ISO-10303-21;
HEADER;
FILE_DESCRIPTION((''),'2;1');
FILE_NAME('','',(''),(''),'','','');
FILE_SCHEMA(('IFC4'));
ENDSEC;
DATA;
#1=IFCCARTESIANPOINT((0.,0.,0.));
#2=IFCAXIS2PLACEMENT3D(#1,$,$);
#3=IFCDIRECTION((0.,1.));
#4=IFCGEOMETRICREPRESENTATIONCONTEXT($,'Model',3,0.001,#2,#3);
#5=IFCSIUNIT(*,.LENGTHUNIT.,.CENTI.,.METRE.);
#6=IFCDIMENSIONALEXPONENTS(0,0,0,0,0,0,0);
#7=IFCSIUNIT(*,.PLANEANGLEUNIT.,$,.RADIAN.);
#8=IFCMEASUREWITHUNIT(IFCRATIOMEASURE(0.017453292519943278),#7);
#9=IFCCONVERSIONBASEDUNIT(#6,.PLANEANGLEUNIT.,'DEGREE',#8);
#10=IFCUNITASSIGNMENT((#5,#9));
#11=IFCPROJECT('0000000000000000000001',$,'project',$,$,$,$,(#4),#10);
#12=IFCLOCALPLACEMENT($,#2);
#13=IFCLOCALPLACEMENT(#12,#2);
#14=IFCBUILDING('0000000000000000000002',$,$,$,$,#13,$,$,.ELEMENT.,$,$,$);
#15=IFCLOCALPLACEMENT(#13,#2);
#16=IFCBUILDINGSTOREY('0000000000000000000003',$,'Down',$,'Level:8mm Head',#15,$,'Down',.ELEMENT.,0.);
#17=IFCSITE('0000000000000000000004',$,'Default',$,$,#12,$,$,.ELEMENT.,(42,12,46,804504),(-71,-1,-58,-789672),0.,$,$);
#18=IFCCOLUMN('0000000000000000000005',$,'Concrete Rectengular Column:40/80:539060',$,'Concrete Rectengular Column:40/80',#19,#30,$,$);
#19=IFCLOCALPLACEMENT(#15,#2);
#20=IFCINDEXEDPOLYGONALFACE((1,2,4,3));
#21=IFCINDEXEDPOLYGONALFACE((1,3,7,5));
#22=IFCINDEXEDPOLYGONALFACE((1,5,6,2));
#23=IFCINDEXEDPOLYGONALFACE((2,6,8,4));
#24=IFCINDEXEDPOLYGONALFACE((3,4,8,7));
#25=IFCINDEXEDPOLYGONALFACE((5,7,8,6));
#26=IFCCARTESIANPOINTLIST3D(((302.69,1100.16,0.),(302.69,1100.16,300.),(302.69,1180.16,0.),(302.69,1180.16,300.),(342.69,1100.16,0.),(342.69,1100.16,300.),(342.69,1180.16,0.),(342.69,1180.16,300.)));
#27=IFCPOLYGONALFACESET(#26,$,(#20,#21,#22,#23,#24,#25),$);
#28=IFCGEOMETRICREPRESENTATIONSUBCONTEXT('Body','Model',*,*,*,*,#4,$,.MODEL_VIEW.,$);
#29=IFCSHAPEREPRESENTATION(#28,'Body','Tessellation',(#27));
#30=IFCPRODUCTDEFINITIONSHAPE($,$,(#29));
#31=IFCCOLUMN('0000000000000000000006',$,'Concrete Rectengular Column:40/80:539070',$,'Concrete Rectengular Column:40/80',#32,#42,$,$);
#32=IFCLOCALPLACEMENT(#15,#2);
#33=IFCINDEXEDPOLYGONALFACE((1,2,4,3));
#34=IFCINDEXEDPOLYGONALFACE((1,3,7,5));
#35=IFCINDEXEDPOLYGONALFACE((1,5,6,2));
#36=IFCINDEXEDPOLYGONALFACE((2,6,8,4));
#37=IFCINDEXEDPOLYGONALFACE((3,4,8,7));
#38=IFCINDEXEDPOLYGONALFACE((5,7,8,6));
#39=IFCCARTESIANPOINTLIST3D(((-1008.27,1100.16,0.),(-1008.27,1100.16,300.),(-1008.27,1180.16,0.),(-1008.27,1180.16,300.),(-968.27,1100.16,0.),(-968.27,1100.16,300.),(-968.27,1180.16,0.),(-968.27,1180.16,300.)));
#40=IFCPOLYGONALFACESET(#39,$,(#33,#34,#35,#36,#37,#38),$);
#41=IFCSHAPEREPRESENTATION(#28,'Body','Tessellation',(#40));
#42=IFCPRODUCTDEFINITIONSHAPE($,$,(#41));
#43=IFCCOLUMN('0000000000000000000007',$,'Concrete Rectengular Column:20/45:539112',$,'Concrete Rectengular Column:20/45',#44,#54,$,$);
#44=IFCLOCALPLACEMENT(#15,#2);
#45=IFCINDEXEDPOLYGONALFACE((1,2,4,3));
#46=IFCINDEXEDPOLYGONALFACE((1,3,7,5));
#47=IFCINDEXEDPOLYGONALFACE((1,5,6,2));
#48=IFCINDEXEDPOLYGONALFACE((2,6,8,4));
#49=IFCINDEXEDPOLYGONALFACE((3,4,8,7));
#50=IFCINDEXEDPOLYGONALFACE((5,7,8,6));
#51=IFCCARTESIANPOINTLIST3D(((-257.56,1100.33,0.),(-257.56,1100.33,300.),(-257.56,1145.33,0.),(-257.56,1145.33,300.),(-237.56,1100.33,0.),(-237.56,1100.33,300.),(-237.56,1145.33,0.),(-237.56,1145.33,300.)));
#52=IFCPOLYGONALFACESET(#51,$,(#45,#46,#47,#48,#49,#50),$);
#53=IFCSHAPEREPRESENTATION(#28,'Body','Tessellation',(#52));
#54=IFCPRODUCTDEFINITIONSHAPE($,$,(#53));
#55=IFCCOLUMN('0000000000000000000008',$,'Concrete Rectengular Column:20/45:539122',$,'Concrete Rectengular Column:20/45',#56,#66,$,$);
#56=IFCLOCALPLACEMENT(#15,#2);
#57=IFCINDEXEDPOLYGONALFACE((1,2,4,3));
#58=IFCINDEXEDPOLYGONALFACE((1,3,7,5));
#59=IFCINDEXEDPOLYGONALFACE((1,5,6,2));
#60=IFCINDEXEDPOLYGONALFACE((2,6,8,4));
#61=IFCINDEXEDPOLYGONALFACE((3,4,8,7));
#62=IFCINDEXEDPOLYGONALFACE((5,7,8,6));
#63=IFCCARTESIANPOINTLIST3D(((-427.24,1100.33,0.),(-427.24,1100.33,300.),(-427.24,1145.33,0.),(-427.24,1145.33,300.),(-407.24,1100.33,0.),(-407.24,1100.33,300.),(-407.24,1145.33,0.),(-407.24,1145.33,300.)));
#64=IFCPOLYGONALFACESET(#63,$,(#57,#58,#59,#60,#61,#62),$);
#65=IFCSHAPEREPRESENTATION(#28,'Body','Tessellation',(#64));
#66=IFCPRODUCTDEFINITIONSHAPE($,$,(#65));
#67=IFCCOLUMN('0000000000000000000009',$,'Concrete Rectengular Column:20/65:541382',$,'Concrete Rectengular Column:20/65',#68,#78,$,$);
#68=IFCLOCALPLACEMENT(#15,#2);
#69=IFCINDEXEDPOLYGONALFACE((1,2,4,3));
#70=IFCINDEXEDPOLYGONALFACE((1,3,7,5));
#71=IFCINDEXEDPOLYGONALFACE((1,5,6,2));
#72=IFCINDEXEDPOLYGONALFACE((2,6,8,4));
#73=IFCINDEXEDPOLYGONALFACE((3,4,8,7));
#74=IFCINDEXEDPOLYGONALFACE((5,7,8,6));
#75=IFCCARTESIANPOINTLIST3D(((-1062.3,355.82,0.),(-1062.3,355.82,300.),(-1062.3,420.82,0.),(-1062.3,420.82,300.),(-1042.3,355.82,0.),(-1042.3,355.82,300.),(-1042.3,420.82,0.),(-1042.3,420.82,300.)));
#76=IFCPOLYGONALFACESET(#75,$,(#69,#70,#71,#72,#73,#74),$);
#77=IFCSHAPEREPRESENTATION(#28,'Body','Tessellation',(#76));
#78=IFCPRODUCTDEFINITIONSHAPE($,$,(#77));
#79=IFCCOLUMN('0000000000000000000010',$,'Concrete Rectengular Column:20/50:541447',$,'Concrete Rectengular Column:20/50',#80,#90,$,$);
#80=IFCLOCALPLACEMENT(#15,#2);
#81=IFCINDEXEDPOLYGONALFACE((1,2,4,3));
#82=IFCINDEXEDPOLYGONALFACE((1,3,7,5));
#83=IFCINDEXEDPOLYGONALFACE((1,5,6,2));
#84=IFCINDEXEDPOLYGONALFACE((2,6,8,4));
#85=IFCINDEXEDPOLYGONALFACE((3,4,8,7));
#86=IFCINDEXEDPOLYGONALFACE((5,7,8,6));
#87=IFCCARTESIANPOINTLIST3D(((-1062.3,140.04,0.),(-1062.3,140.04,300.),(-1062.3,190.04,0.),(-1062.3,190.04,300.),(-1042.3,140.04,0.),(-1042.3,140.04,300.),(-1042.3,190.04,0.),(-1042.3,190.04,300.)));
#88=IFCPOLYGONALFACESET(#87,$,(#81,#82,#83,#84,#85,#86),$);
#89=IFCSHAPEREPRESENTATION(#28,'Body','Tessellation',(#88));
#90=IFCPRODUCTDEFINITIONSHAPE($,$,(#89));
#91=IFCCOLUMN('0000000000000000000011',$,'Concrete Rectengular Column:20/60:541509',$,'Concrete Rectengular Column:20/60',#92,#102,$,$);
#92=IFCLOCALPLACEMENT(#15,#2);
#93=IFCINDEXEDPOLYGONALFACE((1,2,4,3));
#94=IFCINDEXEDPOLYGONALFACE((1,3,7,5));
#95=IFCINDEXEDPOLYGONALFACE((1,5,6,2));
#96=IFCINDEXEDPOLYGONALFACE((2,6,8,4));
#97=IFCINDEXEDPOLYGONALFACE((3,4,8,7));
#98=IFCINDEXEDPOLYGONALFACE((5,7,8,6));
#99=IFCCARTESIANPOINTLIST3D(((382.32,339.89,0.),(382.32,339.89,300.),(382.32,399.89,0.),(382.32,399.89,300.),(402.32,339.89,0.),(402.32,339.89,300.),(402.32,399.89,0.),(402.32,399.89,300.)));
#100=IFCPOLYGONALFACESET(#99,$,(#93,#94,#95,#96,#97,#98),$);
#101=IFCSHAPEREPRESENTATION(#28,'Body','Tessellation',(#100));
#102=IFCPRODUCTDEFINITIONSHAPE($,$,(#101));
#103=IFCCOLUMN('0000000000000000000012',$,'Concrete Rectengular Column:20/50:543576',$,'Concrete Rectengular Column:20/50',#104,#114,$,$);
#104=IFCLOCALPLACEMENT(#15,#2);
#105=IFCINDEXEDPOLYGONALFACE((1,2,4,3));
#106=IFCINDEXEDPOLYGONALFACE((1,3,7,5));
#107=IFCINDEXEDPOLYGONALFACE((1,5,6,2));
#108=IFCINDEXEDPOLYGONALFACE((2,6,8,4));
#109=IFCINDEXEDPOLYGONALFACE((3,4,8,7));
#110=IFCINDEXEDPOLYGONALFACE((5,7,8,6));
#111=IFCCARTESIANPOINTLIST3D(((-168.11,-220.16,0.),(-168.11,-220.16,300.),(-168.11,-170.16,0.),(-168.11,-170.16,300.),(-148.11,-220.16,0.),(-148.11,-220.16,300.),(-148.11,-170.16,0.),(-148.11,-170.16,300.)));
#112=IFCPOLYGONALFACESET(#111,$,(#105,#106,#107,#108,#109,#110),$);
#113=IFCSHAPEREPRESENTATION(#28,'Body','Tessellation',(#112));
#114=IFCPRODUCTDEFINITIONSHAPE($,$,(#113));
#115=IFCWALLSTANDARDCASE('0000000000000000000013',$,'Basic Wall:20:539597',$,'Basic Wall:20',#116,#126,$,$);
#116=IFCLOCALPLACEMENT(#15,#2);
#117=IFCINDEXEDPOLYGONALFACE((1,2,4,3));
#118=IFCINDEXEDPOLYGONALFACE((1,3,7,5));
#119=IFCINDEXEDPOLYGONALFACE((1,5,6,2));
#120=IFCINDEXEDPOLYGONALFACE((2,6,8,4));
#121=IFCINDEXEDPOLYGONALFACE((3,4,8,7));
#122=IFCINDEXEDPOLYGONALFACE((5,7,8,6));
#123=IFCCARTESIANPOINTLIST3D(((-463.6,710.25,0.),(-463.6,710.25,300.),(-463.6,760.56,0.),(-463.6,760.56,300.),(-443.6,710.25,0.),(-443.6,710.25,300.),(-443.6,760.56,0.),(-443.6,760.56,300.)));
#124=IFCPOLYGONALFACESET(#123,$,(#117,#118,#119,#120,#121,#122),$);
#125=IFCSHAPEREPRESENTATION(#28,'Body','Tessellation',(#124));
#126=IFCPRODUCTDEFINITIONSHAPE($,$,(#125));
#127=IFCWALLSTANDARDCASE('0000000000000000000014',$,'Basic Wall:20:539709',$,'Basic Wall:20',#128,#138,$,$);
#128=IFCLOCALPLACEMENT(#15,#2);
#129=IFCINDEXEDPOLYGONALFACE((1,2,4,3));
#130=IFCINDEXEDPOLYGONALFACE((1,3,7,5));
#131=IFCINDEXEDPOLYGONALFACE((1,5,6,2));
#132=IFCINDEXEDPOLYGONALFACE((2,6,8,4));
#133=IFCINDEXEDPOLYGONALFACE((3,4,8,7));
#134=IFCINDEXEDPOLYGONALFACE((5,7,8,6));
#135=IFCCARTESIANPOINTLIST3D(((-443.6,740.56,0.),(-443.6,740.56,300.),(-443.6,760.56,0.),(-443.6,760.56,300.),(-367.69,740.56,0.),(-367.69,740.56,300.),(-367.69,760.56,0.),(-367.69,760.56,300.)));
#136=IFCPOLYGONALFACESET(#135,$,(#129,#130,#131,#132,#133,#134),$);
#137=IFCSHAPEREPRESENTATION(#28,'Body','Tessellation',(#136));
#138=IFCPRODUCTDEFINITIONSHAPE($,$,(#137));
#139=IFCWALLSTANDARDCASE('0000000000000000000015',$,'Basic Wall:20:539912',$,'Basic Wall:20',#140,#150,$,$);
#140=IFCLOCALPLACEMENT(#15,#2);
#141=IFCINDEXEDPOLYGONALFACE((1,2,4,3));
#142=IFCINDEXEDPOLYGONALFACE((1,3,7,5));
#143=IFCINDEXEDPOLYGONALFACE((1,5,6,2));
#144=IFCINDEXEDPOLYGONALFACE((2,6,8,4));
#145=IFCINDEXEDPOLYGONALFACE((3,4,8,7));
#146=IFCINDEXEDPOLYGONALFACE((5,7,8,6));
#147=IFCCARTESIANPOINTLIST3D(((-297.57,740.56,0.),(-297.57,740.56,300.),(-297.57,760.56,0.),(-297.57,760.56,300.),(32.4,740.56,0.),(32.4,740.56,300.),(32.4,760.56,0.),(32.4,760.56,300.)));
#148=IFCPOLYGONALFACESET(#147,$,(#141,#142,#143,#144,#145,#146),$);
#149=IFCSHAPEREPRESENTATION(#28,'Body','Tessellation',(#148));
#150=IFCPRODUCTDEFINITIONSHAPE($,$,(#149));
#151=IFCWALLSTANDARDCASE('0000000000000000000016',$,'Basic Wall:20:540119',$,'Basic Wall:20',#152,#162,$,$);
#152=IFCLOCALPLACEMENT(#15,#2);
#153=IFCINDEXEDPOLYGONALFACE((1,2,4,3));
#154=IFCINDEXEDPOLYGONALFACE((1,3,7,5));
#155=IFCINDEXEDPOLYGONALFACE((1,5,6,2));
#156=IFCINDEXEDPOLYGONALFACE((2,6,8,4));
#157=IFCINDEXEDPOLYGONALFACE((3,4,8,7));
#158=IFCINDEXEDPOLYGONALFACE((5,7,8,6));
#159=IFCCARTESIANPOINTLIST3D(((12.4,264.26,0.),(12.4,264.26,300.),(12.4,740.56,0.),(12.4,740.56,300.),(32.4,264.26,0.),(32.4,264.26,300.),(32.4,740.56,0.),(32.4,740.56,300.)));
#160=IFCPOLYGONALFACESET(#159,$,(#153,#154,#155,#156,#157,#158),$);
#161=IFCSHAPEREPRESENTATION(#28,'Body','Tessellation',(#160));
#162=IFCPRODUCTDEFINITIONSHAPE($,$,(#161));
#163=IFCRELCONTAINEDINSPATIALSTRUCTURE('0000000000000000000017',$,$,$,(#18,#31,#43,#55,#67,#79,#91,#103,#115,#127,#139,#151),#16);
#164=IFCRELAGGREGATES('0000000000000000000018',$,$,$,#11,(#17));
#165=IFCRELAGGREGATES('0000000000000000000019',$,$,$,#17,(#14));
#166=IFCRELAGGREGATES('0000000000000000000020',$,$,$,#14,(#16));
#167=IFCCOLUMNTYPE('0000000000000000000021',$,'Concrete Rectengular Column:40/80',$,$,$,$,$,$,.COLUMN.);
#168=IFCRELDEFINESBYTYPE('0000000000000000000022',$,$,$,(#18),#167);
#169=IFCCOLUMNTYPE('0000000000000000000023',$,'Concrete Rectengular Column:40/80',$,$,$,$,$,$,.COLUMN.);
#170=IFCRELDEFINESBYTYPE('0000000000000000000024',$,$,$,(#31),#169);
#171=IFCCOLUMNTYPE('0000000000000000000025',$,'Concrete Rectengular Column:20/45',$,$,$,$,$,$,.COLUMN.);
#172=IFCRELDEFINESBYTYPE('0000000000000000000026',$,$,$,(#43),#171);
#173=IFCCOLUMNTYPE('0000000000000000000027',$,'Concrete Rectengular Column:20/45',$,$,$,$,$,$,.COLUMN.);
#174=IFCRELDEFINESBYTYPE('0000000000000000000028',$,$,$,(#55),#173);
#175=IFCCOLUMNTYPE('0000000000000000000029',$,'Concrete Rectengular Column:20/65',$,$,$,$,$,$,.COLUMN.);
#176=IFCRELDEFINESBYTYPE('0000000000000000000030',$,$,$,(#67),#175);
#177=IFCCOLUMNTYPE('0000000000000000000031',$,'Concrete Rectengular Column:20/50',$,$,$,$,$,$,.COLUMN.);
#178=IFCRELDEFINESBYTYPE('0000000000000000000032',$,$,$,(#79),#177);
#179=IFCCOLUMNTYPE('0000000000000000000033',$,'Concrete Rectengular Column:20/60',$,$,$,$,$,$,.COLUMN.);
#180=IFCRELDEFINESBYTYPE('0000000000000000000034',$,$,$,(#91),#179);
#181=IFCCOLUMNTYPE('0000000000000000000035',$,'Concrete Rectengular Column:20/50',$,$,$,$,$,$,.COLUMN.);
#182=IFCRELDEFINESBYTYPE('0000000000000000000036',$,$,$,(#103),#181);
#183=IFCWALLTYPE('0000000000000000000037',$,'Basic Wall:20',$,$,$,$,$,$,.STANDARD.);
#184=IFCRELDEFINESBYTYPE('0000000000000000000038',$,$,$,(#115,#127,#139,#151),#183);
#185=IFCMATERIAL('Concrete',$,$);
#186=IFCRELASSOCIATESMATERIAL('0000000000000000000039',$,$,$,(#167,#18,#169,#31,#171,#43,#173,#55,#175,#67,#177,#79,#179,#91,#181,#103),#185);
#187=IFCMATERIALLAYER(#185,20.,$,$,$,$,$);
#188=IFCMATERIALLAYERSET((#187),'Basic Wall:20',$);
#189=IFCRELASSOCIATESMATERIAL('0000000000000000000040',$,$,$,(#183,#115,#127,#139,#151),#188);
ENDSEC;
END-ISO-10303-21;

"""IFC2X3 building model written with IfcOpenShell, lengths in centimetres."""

from ifc_helpers import new_model, entity, si_unit, converted_unit, direction, frame, frame_2d, origin, origin_2d_with_axis, place, context, subcontext, project, spatial, rectangle, extrude, source, transform, mapped, material, layer, layer_set, layer_usage, type_object, type_shapes, element, save


model = new_model("IFC2X3")

# Units and contexts
model_context = context("Model", 3, precision=0.001, world=origin(), true_north=direction((0.0, 1.0)))
body_context = subcontext(model_context, "Body", "Model", "MODEL_VIEW")
ifc_project = project(units=[si_unit("LENGTHUNIT", "METRE", prefix="CENTI"), converted_unit("PLANEANGLEUNIT", "DEGREE", entity("IfcRatioMeasure", 0.017453292519943278), si_unit("PLANEANGLEUNIT", "RADIAN"), dimensions=[0, 0, 0, 0, 0, 0, 0])], contexts=[model_context])

# Site, building, storey
site_placement = place(None, origin())
site = spatial("IfcSite", under=ifc_project, at=site_placement, Name="Default", CompositionType="ELEMENT", RefLatitude=(42, 12, 46, 804504), RefLongitude=(-71, -1, -58, -789672), RefElevation=0.0)
building_placement = place(site_placement, origin())
building = spatial("IfcBuilding", under=site, at=building_placement, CompositionType="ELEMENT")
storey_placement = place(building_placement, origin())
storey = spatial("IfcBuildingStorey", under=building, at=storey_placement, Name="Down", ObjectType="Level:8mm Head", LongName="Down", CompositionType="ELEMENT", Elevation=0.0)

# Columns
ifc_material = material(Name="Concrete")
column_type_1 = type_object("IfcColumnType", Name="Concrete Rectengular Column:40/80", PredefinedType="COLUMN", material=ifc_material)
shared_shape_1 = source(origin(), body_context, "Body", "SweptSolid", [
    extrude(rectangle(XDim=80.0, YDim=40.0, at=origin_2d_with_axis()), frame((322.69, 1140.16, 0.0), z_axis=(0.0, 0.0, 1.0), x_axis=(0.0, -1.0, 0.0)), (0.0, 0.0, 1.0), 300.0),
])
type_shapes(column_type_1, [shared_shape_1])
column_1_placement = place(storey_placement, origin())
element("IfcColumn", 1, at=column_1_placement, inside=storey, type_object=column_type_1, material=ifc_material, Name="Concrete Rectengular Column:40/80:539060", ObjectType="Concrete Rectengular Column:40/80", context=body_context, shape_type="MappedRepresentation", body=[
    mapped(shared_shape_1, transform((0.0, 0.0, 0.0), scale=1.0)),
])
column_type_2 = type_object("IfcColumnType", Name="Concrete Rectengular Column:40/80", PredefinedType="COLUMN", material=ifc_material)
shared_shape_2 = source(origin(), body_context, "Body", "SweptSolid", [
    extrude(rectangle(XDim=80.0, YDim=40.0, at=origin_2d_with_axis()), frame((-988.27, 1140.16, 0.0), z_axis=(0.0, 0.0, 1.0), x_axis=(0.0, -1.0, 0.0)), (0.0, 0.0, 1.0), 300.0),
])
type_shapes(column_type_2, [shared_shape_2])
column_2_placement = place(storey_placement, origin())
element("IfcColumn", 2, at=column_2_placement, inside=storey, type_object=column_type_2, material=ifc_material, Name="Concrete Rectengular Column:40/80:539070", ObjectType="Concrete Rectengular Column:40/80", context=body_context, shape_type="MappedRepresentation", body=[
    mapped(shared_shape_2, transform((0.0, 0.0, 0.0), scale=1.0)),
])
column_type_3 = type_object("IfcColumnType", Name="Concrete Rectengular Column:20/45", PredefinedType="COLUMN", material=ifc_material)
shared_shape_3 = source(origin(), body_context, "Body", "SweptSolid", [
    extrude(rectangle(XDim=45.0, YDim=20.0, at=origin_2d_with_axis()), frame((-247.56, 1122.83, 0.0), z_axis=(0.0, 0.0, 1.0), x_axis=(0.0, -1.0, 0.0)), (0.0, 0.0, 1.0), 300.0),
])
type_shapes(column_type_3, [shared_shape_3])
column_3_placement = place(storey_placement, origin())
element("IfcColumn", 3, at=column_3_placement, inside=storey, type_object=column_type_3, material=ifc_material, Name="Concrete Rectengular Column:20/45:539112", ObjectType="Concrete Rectengular Column:20/45", context=body_context, shape_type="MappedRepresentation", body=[
    mapped(shared_shape_3, transform((0.0, 0.0, 0.0), scale=1.0)),
])
column_type_4 = type_object("IfcColumnType", Name="Concrete Rectengular Column:20/45", PredefinedType="COLUMN", material=ifc_material)
shared_shape_4 = source(origin(), body_context, "Body", "SweptSolid", [
    extrude(rectangle(XDim=45.0, YDim=20.0, at=origin_2d_with_axis()), frame((-417.24, 1122.83, 0.0), z_axis=(0.0, 0.0, 1.0), x_axis=(0.0, -1.0, 0.0)), (0.0, 0.0, 1.0), 300.0),
])
type_shapes(column_type_4, [shared_shape_4])
column_4_placement = place(storey_placement, origin())
element("IfcColumn", 4, at=column_4_placement, inside=storey, type_object=column_type_4, material=ifc_material, Name="Concrete Rectengular Column:20/45:539122", ObjectType="Concrete Rectengular Column:20/45", context=body_context, shape_type="MappedRepresentation", body=[
    mapped(shared_shape_4, transform((0.0, 0.0, 0.0), scale=1.0)),
])
column_type_5 = type_object("IfcColumnType", Name="Concrete Rectengular Column:20/65", PredefinedType="COLUMN", material=ifc_material)
shared_shape_5 = source(origin(), body_context, "Body", "SweptSolid", [
    extrude(rectangle(XDim=65.0, YDim=20.0, at=frame_2d((0.0, 0.0), x_axis=(1.0, 0.0))), frame((-1052.3, 388.32, 0.0), z_axis=(0.0, 0.0, 1.0), x_axis=(0.0, -1.0, 0.0)), (0.0, 0.0, 1.0), 300.0),
])
type_shapes(column_type_5, [shared_shape_5])
column_5_placement = place(storey_placement, origin())
element("IfcColumn", 5, at=column_5_placement, inside=storey, type_object=column_type_5, material=ifc_material, Name="Concrete Rectengular Column:20/65:541382", ObjectType="Concrete Rectengular Column:20/65", context=body_context, shape_type="MappedRepresentation", body=[
    mapped(shared_shape_5, transform((0.0, 0.0, 0.0), scale=1.0)),
])
column_type_6 = type_object("IfcColumnType", Name="Concrete Rectengular Column:20/50", PredefinedType="COLUMN", material=ifc_material)
shared_shape_6 = source(origin(), body_context, "Body", "SweptSolid", [
    extrude(rectangle(XDim=50.0, YDim=20.0, at=frame_2d((0.0, 0.0), x_axis=(1.0, 0.0))), frame((-1052.3, 165.04, 0.0), z_axis=(0.0, 0.0, 1.0), x_axis=(0.0, -1.0, 0.0)), (0.0, 0.0, 1.0), 300.0),
])
type_shapes(column_type_6, [shared_shape_6])
column_6_placement = place(storey_placement, origin())
element("IfcColumn", 6, at=column_6_placement, inside=storey, type_object=column_type_6, material=ifc_material, Name="Concrete Rectengular Column:20/50:541447", ObjectType="Concrete Rectengular Column:20/50", context=body_context, shape_type="MappedRepresentation", body=[
    mapped(shared_shape_6, transform((0.0, 0.0, 0.0), scale=1.0)),
])
column_type_7 = type_object("IfcColumnType", Name="Concrete Rectengular Column:20/60", PredefinedType="COLUMN", material=ifc_material)
shared_shape_7 = source(origin(), body_context, "Body", "SweptSolid", [
    extrude(rectangle(XDim=60.0, YDim=20.0, at=origin_2d_with_axis()), frame((392.32, 369.89, 0.0), z_axis=(0.0, 0.0, 1.0), x_axis=(0.0, -1.0, 0.0)), (0.0, 0.0, 1.0), 300.0),
])
type_shapes(column_type_7, [shared_shape_7])
column_7_placement = place(storey_placement, origin())
element("IfcColumn", 7, at=column_7_placement, inside=storey, type_object=column_type_7, material=ifc_material, Name="Concrete Rectengular Column:20/60:541509", ObjectType="Concrete Rectengular Column:20/60", context=body_context, shape_type="MappedRepresentation", body=[
    mapped(shared_shape_7, transform((0.0, 0.0, 0.0), scale=1.0)),
])
column_type_8 = type_object("IfcColumnType", Name="Concrete Rectengular Column:20/50", PredefinedType="COLUMN", material=ifc_material)
shared_shape_8 = source(origin(), body_context, "Body", "SweptSolid", [
    extrude(rectangle(XDim=50.0, YDim=20.0, at=frame_2d((0.0, 0.0), x_axis=(1.0, 0.0))), frame((-158.11, -195.16, 0.0), z_axis=(0.0, 0.0, 1.0), x_axis=(0.0, -1.0, 0.0)), (0.0, 0.0, 1.0), 300.0),
])
type_shapes(column_type_8, [shared_shape_8])
column_8_placement = place(storey_placement, origin())
element("IfcColumn", 8, at=column_8_placement, inside=storey, type_object=column_type_8, material=ifc_material, Name="Concrete Rectengular Column:20/50:543576", ObjectType="Concrete Rectengular Column:20/50", context=body_context, shape_type="MappedRepresentation", body=[
    mapped(shared_shape_8, transform((0.0, 0.0, 0.0), scale=1.0)),
])

# Walls
ifc_layer_1 = layer(ifc_material, 20.0)
ifc_layer_set_1 = layer_set([ifc_layer_1], Name="Basic Wall:20")
ifc_layer_usage_1 = layer_usage(ifc_layer_set_1, "AXIS2", "NEGATIVE", 10.0)
wall_type_1 = type_object("IfcWallType", Name="Basic Wall:20", PredefinedType="STANDARD", material=ifc_layer_set_1)
wall_1_placement = place(storey_placement, frame((-453.6, 710.25, 0.0), z_axis=(0.0, 0.0, 1.0), x_axis=(0.0, 1.0, 0.0)))
element("IfcWallStandardCase", 9, at=wall_1_placement, inside=storey, type_object=wall_type_1, material=ifc_layer_usage_1, Name="Basic Wall:20:539597", ObjectType="Basic Wall:20", context=body_context, shape_type="SweptSolid", body=[
    extrude(rectangle(XDim=50.31, YDim=20.0, at=frame_2d((25.15, 0.0), x_axis=(-1.0, 0.0))), origin(), (0.0, 0.0, 1.0), 300.0),
])
ifc_layer_usage_2 = layer_usage(ifc_layer_set_1, "AXIS2", "NEGATIVE", 10.0)
wall_2_placement = place(storey_placement, frame((-443.6, 750.56, 0.0)))
element("IfcWallStandardCase", 10, at=wall_2_placement, inside=storey, type_object=wall_type_1, material=ifc_layer_usage_2, Name="Basic Wall:20:539709", ObjectType="Basic Wall:20", context=body_context, shape_type="SweptSolid", body=[
    extrude(rectangle(XDim=75.91, YDim=20.0, at=frame_2d((37.96, 0.0), x_axis=(-1.0, 0.0))), origin(), (0.0, 0.0, 1.0), 300.0),
])
ifc_layer_usage_3 = layer_usage(ifc_layer_set_1, "AXIS2", "NEGATIVE", 10.0)
wall_3_placement = place(storey_placement, frame((-297.57, 750.56, 0.0)))
element("IfcWallStandardCase", 11, at=wall_3_placement, inside=storey, type_object=wall_type_1, material=ifc_layer_usage_3, Name="Basic Wall:20:539912", ObjectType="Basic Wall:20", context=body_context, shape_type="SweptSolid", body=[
    extrude(rectangle(XDim=329.97, YDim=20.0, at=frame_2d((164.98, 0.0), x_axis=(-1.0, 0.0))), origin(), (0.0, 0.0, 1.0), 300.0),
])
ifc_layer_usage_4 = layer_usage(ifc_layer_set_1, "AXIS2", "NEGATIVE", 10.0)
wall_4_placement = place(storey_placement, frame((22.4, 740.56, 0.0), z_axis=(0.0, 0.0, 1.0), x_axis=(0.0, -1.0, 0.0)))
element("IfcWallStandardCase", 12, at=wall_4_placement, inside=storey, type_object=wall_type_1, material=ifc_layer_usage_4, Name="Basic Wall:20:540119", ObjectType="Basic Wall:20", context=body_context, shape_type="SweptSolid", body=[
    extrude(rectangle(XDim=476.3, YDim=20.0, at=frame_2d((238.15, 0.0), x_axis=(-1.0, 0.0))), origin(), (0.0, 0.0, 1.0), 300.0),
])

save(model, "model.ifc")
